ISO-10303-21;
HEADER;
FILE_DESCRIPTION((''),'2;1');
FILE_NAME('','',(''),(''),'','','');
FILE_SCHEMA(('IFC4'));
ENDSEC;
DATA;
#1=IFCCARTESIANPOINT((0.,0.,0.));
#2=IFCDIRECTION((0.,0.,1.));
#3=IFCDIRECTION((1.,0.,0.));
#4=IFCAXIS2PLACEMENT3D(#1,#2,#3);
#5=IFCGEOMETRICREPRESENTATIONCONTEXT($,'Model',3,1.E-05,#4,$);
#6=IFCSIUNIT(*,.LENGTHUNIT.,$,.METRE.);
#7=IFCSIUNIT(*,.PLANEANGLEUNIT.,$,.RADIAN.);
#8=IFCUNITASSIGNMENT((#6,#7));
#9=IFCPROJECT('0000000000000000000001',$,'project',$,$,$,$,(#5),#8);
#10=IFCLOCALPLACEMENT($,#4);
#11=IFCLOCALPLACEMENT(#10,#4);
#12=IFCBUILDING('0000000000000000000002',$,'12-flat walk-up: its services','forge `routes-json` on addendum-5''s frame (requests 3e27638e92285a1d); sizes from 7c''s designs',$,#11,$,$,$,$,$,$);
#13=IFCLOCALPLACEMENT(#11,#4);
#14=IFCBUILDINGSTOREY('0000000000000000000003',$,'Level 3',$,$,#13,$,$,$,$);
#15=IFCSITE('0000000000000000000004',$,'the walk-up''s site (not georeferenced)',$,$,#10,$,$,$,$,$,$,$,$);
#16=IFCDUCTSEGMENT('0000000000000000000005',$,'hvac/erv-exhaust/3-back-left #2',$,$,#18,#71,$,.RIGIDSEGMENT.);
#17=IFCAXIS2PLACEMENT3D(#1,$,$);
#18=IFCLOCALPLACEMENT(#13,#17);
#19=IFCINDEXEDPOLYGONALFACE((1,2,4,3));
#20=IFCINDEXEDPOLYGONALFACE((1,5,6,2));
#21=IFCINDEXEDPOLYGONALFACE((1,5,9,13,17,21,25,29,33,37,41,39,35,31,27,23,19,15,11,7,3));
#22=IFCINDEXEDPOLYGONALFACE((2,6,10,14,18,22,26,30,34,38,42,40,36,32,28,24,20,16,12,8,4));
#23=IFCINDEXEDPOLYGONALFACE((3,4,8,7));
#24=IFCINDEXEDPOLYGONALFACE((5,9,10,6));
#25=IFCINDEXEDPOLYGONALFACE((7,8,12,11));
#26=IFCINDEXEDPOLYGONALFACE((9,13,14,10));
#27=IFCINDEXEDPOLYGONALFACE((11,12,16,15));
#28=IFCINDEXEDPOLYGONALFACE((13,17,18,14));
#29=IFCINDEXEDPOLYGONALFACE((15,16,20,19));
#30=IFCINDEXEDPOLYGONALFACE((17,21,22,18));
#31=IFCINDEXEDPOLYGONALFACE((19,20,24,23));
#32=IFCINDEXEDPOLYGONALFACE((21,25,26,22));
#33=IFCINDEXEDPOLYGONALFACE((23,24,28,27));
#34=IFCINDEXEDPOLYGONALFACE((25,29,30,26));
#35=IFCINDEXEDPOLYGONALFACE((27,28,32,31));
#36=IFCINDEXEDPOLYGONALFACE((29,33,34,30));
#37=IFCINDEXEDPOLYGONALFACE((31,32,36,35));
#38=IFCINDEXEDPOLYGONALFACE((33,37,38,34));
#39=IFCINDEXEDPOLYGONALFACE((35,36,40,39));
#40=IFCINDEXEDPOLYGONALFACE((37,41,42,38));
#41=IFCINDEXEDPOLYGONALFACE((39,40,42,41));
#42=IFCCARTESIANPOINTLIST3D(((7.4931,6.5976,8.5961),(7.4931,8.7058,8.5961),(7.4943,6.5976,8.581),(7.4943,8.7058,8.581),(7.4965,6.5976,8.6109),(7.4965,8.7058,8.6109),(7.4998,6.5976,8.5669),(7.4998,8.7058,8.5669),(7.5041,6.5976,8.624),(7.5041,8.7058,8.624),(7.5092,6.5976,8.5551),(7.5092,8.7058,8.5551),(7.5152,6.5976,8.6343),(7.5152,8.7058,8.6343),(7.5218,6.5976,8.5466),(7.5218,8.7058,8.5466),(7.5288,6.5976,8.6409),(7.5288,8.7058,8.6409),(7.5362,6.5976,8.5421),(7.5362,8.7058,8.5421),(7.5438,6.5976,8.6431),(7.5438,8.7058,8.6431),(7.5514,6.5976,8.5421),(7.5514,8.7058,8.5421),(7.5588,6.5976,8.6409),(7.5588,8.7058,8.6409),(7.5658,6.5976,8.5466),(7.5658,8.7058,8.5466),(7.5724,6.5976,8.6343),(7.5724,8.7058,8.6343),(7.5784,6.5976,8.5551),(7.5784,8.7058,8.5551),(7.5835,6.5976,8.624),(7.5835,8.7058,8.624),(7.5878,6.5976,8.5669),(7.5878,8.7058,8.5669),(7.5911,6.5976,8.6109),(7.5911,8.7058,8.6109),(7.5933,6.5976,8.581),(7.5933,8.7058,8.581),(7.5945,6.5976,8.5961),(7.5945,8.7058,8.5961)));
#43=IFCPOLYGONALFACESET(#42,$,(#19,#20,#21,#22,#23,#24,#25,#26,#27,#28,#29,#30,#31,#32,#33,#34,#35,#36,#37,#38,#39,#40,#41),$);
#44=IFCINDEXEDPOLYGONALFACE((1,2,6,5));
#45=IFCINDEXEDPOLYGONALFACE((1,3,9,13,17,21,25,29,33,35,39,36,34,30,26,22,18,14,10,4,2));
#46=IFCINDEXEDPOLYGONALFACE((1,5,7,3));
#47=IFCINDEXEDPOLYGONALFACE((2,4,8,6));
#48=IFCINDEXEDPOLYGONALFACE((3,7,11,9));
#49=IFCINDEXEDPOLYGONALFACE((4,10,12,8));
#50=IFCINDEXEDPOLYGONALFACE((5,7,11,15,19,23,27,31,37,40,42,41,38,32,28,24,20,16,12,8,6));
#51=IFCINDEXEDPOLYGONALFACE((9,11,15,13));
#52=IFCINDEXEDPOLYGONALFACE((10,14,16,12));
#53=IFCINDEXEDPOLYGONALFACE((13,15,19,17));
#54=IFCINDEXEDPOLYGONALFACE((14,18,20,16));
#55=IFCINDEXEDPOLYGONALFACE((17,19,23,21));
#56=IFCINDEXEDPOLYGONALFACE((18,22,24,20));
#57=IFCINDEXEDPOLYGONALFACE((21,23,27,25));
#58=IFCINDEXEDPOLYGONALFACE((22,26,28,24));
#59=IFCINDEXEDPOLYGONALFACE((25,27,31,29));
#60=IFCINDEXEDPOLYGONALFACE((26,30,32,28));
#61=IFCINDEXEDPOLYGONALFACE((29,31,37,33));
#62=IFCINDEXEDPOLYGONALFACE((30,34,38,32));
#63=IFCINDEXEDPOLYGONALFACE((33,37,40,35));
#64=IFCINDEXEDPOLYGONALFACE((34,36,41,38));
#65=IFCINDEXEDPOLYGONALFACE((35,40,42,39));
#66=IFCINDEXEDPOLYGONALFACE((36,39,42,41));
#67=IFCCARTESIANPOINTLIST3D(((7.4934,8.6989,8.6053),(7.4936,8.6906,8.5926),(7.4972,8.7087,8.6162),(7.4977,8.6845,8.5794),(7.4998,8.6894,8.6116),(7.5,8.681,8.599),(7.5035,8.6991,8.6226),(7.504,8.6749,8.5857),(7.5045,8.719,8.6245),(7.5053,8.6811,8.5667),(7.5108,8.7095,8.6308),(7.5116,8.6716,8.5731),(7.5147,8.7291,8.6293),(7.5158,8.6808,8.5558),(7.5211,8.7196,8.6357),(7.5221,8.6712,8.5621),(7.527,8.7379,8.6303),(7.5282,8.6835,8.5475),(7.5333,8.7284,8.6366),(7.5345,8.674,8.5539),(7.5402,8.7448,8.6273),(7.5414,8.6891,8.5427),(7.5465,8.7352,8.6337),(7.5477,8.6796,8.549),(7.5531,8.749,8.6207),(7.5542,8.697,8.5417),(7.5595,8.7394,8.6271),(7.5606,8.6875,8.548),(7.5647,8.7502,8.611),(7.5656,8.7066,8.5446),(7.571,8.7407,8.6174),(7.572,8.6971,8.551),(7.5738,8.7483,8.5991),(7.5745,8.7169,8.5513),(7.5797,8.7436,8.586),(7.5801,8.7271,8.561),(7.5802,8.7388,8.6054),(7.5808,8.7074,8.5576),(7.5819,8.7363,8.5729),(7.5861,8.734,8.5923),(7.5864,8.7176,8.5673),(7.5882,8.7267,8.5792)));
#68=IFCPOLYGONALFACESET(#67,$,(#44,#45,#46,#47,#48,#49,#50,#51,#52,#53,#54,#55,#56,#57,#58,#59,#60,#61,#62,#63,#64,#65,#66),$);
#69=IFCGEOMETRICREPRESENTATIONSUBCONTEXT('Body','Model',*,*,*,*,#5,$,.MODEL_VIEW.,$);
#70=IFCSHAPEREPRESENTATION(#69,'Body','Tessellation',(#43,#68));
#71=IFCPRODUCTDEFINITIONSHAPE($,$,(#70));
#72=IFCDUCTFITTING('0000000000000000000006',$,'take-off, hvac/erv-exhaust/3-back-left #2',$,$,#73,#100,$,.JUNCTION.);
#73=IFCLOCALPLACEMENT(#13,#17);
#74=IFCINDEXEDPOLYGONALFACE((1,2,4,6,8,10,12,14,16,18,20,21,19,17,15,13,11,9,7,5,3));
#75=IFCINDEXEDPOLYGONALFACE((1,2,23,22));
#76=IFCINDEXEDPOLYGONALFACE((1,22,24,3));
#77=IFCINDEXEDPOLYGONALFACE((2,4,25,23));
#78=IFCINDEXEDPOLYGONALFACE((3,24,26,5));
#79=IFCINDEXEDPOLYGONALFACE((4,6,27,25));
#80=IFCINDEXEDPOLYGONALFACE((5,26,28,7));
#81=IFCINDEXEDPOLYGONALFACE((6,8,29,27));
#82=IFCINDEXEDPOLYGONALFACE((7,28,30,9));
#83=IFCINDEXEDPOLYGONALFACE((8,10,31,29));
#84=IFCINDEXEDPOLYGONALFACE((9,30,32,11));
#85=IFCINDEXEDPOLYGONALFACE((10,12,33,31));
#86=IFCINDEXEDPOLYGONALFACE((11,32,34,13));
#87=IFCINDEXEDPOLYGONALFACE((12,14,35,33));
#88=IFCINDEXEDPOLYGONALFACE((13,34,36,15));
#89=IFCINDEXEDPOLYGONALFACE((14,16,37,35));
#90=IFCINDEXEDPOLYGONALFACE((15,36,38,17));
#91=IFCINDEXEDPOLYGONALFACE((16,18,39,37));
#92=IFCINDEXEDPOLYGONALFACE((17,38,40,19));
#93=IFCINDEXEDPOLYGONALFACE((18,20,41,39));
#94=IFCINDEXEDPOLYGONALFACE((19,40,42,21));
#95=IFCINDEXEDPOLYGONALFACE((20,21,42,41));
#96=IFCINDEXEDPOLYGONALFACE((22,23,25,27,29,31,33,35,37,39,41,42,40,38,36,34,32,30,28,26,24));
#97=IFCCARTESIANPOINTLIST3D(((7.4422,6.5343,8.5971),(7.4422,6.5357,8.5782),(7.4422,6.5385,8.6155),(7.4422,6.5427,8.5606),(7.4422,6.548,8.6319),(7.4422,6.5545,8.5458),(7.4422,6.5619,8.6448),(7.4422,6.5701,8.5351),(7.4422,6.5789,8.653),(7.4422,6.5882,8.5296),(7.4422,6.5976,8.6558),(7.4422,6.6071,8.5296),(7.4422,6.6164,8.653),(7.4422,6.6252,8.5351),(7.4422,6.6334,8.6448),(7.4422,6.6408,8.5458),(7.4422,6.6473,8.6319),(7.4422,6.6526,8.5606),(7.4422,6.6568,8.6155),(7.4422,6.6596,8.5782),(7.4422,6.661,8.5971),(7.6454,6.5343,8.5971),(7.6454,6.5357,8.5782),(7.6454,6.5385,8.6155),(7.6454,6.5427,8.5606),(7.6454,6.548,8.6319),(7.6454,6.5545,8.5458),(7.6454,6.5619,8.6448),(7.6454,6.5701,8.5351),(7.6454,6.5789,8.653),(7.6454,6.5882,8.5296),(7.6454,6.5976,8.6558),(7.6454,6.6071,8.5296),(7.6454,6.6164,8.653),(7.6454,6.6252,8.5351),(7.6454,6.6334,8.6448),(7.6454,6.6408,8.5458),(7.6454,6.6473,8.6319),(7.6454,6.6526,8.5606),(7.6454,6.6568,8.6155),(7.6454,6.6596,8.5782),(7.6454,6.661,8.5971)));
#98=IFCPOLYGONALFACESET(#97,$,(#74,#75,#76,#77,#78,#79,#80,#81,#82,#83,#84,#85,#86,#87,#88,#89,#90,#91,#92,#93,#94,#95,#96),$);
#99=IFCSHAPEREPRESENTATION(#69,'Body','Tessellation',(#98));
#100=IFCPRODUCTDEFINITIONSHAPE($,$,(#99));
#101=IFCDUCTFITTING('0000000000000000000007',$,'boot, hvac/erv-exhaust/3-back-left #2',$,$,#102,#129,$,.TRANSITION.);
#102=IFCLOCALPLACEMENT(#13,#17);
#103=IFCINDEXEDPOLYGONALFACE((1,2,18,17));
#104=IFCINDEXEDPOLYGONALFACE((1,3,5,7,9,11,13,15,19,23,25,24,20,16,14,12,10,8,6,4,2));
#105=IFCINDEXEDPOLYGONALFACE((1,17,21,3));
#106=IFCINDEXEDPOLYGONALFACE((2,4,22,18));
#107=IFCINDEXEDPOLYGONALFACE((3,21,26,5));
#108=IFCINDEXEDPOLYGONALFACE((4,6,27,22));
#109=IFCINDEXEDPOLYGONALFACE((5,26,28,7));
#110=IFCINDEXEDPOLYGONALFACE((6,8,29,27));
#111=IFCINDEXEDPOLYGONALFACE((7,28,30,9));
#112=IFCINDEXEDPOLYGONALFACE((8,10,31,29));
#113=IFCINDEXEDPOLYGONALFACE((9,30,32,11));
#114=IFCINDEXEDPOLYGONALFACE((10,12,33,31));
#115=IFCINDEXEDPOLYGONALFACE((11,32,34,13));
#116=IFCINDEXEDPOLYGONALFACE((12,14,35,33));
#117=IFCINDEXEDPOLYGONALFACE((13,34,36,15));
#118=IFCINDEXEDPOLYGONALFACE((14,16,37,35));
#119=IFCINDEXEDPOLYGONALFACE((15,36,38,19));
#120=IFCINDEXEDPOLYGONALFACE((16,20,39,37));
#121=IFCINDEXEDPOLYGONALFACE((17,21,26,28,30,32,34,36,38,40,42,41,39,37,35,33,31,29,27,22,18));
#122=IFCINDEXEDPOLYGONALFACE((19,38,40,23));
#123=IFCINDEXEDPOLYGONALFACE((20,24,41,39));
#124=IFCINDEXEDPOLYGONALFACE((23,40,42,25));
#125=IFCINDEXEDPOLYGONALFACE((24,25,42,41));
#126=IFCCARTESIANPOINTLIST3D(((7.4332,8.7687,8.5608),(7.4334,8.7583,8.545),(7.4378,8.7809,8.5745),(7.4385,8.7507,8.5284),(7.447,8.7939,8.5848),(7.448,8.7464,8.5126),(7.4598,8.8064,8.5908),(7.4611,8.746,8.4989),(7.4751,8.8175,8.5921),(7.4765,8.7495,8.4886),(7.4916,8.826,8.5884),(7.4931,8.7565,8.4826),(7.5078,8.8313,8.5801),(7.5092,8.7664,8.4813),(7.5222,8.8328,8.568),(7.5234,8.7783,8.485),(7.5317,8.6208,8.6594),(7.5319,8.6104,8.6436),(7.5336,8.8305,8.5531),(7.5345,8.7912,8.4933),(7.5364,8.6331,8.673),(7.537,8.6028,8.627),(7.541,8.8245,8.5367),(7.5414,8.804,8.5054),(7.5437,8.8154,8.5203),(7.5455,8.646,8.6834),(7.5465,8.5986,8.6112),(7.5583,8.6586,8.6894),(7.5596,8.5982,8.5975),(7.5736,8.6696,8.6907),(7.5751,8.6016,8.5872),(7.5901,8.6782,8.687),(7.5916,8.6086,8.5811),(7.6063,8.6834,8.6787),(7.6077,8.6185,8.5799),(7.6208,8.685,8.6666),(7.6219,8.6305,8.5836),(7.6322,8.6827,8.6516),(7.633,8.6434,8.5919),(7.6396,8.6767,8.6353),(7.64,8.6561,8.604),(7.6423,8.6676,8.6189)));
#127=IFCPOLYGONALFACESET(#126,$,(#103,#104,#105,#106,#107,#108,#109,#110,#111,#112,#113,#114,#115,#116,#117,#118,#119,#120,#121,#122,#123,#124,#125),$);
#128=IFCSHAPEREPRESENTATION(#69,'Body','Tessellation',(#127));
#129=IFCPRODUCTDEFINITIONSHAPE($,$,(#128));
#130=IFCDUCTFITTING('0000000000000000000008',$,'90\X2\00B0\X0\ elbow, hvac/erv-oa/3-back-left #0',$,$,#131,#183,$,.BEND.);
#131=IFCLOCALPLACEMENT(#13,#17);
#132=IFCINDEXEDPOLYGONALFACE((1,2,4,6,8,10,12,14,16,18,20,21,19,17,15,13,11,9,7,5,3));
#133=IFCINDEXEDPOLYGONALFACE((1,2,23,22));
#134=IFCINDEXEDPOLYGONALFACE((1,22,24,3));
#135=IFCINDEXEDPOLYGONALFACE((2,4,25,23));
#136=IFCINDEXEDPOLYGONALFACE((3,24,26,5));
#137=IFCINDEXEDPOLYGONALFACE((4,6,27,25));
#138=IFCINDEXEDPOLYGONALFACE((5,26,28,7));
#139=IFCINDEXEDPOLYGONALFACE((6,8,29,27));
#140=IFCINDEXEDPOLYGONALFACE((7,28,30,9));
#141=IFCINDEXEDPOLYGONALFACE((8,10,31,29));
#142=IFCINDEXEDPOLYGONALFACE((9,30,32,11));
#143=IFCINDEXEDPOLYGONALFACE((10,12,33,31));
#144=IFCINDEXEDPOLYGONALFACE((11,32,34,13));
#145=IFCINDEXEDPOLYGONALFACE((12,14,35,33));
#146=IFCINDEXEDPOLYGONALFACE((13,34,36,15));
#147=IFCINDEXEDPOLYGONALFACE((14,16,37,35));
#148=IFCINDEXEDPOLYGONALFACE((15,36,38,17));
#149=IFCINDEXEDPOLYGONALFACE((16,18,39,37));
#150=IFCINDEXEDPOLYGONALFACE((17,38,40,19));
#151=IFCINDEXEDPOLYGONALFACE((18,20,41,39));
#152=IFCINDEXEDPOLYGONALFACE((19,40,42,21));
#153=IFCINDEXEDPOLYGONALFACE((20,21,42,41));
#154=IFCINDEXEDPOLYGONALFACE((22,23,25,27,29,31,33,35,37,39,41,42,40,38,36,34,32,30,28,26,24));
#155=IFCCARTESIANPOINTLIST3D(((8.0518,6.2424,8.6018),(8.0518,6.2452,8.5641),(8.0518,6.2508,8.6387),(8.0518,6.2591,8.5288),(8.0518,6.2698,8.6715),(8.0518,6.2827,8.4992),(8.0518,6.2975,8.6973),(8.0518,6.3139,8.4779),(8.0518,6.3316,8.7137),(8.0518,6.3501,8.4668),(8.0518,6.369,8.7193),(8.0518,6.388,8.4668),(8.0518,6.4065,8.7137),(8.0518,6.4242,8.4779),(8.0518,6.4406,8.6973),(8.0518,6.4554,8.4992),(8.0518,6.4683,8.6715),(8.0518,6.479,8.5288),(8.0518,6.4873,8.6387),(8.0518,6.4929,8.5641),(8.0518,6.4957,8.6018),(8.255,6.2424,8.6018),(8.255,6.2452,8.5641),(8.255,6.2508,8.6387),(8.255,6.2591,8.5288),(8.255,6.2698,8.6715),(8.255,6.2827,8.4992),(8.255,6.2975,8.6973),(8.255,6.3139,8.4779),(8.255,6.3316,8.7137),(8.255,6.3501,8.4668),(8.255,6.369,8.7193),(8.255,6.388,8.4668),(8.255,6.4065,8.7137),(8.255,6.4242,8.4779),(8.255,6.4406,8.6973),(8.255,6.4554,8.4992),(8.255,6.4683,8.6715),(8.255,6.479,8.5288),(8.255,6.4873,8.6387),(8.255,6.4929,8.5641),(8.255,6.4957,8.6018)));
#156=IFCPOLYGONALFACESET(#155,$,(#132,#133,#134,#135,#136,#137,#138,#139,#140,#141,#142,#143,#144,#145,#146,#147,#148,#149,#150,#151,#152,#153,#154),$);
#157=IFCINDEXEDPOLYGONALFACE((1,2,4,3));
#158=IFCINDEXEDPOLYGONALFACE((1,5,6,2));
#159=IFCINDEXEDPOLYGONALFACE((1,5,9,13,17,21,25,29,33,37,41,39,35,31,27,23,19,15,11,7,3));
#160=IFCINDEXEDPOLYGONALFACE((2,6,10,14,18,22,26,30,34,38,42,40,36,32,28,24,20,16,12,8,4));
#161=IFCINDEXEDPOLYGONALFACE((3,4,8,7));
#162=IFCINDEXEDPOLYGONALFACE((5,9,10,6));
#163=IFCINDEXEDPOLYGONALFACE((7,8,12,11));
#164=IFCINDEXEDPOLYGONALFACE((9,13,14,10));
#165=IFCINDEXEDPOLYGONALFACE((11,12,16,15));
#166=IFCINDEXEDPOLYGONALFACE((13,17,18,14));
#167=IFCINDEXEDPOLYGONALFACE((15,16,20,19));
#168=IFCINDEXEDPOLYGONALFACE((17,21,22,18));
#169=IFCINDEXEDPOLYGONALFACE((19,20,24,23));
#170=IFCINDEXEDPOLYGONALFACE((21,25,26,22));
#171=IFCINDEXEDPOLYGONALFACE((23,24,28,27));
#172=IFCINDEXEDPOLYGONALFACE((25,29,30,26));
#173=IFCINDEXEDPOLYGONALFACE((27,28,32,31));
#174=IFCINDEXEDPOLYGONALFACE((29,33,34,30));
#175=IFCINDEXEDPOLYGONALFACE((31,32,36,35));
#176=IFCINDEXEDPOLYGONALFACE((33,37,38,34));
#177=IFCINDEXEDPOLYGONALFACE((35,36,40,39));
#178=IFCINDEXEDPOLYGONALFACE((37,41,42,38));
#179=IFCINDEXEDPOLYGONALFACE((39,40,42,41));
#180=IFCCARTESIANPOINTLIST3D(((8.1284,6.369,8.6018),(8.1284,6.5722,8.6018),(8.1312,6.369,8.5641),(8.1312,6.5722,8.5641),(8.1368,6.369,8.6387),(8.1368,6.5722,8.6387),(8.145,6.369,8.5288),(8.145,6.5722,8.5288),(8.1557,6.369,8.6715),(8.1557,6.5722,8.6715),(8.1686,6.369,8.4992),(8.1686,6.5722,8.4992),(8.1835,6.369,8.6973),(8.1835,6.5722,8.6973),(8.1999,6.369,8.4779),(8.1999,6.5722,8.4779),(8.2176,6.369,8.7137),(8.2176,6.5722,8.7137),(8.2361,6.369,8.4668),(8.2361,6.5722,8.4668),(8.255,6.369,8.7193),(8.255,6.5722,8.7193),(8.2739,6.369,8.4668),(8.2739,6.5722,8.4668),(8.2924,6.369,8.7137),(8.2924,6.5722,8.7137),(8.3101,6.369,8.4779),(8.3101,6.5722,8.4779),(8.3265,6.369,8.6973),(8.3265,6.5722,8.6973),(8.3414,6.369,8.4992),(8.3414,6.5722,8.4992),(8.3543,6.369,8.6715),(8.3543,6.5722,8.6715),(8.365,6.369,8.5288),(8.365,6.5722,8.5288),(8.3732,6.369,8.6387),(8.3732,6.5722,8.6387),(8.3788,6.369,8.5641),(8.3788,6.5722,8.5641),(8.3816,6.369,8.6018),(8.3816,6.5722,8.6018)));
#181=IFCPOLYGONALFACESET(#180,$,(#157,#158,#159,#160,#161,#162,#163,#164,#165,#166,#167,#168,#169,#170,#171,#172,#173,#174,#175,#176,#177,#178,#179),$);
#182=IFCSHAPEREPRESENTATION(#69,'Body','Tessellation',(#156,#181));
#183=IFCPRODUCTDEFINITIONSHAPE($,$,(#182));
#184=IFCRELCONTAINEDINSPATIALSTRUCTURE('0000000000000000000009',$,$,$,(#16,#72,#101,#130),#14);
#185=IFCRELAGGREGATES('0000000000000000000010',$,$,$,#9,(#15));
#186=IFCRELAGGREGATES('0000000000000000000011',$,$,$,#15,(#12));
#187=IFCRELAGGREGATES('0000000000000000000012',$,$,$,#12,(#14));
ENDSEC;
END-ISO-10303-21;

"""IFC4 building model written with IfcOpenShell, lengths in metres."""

from ifc_helpers import new_model, entity, si_unit, frame, origin_with_axes, place, context, subcontext, project, spatial, element, save


model = new_model("IFC4")

# Units and contexts
model_context = context("Model", 3, precision=1e-05, world=origin_with_axes())
body_context = subcontext(model_context, "Body", "Model", "MODEL_VIEW")
ifc_project = project(units=[si_unit("LENGTHUNIT", "METRE"), si_unit("PLANEANGLEUNIT", "RADIAN")], contexts=[model_context])

# Site, building, storey
site_placement = place(None, origin_with_axes())
site = spatial("IfcSite", under=ifc_project, at=site_placement, Name="the walk-up's site (not georeferenced)")
building_placement = place(site_placement, origin_with_axes())
building = spatial("IfcBuilding", under=site, at=building_placement, Name="12-flat walk-up: its services", Description="forge `routes-json` on addendum-5's frame (requests 3e27638e92285a1d); sizes from 7c's designs")
storey_placement = place(building_placement, origin_with_axes())
storey = spatial("IfcBuildingStorey", under=building, at=storey_placement, Name="Level 3")

# Duct segment
duct_segment_1_placement = place(storey_placement, frame((7.5438, 6.5976, 8.5923), z_axis=(0.0, 0.0, 1.0), x_axis=(1.0, 0.0, 0.0)))
element("IfcDuctSegment", 1, at=duct_segment_1_placement, inside=storey, Name="hvac/erv-exhaust/3-back-left #2", PredefinedType="RIGIDSEGMENT", context=body_context, shape_type="AdvancedSweptSolid", body=[
    entity("IfcSweptDiskSolid", entity("IfcPolyline", [entity("IfcCartesianPoint", [0.0, 0.0, 0.0]), entity("IfcCartesianPoint", [0.0, 2.1082, 0.0])]), 0.0508),
    entity("IfcSweptDiskSolid", entity("IfcPolyline", [entity("IfcCartesianPoint", [0.0, 2.1082, 0.0]), entity("IfcCartesianPoint", [-0.0063, 2.1177, -0.0063])]), 0.0508),
])

# Duct fittings
duct_fitting_1_placement = place(storey_placement, frame((7.4422, 6.5976, 8.5923), z_axis=(0.0, 0.0, 1.0), x_axis=(1.0, 0.0, 0.0)))
element("IfcDuctFitting", 2, at=duct_fitting_1_placement, inside=storey, Name="take-off, hvac/erv-exhaust/3-back-left #2", PredefinedType="JUNCTION", context=body_context, shape_type="AdvancedSweptSolid", body=[
    entity("IfcSweptDiskSolid", entity("IfcPolyline", [entity("IfcCartesianPoint", [0.0, 0.0, 0.0]), entity("IfcCartesianPoint", [0.2032, 0.0, 0.0])]), 0.0635),
])
duct_fitting_2_placement = place(storey_placement, frame((7.5867, 8.6414, 8.6353), z_axis=(0.0, 0.0, 1.0), x_axis=(1.0, 0.0, 0.0)))
element("IfcDuctFitting", 3, at=duct_fitting_2_placement, inside=storey, Name="boot, hvac/erv-exhaust/3-back-left #2", PredefinedType="TRANSITION", context=body_context, shape_type="AdvancedSweptSolid", body=[
    entity("IfcSweptDiskSolid", entity("IfcPolyline", [entity("IfcCartesianPoint", [0.0, 0.0, 0.0]), entity("IfcCartesianPoint", [-0.0986, 0.1479, -0.0986])]), 0.0635),
])
duct_fitting_3_placement = place(storey_placement, frame((8.0518, 6.369, 8.5923), z_axis=(0.0, 0.0, 1.0), x_axis=(1.0, 0.0, 0.0)))
element("IfcDuctFitting", 4, at=duct_fitting_3_placement, inside=storey, Name="90° elbow, hvac/erv-oa/3-back-left #0", PredefinedType="BEND", context=body_context, shape_type="AdvancedSweptSolid", body=[
    entity("IfcSweptDiskSolid", entity("IfcPolyline", [entity("IfcCartesianPoint", [0.0, 0.0, 0.0]), entity("IfcCartesianPoint", [0.2032, 0.0, 0.0])]), 0.127),
    entity("IfcSweptDiskSolid", entity("IfcPolyline", [entity("IfcCartesianPoint", [0.2032, 0.0, 0.0]), entity("IfcCartesianPoint", [0.2032, 0.2032, 0.0])]), 0.127),
])

save(model, "model.ifc")
